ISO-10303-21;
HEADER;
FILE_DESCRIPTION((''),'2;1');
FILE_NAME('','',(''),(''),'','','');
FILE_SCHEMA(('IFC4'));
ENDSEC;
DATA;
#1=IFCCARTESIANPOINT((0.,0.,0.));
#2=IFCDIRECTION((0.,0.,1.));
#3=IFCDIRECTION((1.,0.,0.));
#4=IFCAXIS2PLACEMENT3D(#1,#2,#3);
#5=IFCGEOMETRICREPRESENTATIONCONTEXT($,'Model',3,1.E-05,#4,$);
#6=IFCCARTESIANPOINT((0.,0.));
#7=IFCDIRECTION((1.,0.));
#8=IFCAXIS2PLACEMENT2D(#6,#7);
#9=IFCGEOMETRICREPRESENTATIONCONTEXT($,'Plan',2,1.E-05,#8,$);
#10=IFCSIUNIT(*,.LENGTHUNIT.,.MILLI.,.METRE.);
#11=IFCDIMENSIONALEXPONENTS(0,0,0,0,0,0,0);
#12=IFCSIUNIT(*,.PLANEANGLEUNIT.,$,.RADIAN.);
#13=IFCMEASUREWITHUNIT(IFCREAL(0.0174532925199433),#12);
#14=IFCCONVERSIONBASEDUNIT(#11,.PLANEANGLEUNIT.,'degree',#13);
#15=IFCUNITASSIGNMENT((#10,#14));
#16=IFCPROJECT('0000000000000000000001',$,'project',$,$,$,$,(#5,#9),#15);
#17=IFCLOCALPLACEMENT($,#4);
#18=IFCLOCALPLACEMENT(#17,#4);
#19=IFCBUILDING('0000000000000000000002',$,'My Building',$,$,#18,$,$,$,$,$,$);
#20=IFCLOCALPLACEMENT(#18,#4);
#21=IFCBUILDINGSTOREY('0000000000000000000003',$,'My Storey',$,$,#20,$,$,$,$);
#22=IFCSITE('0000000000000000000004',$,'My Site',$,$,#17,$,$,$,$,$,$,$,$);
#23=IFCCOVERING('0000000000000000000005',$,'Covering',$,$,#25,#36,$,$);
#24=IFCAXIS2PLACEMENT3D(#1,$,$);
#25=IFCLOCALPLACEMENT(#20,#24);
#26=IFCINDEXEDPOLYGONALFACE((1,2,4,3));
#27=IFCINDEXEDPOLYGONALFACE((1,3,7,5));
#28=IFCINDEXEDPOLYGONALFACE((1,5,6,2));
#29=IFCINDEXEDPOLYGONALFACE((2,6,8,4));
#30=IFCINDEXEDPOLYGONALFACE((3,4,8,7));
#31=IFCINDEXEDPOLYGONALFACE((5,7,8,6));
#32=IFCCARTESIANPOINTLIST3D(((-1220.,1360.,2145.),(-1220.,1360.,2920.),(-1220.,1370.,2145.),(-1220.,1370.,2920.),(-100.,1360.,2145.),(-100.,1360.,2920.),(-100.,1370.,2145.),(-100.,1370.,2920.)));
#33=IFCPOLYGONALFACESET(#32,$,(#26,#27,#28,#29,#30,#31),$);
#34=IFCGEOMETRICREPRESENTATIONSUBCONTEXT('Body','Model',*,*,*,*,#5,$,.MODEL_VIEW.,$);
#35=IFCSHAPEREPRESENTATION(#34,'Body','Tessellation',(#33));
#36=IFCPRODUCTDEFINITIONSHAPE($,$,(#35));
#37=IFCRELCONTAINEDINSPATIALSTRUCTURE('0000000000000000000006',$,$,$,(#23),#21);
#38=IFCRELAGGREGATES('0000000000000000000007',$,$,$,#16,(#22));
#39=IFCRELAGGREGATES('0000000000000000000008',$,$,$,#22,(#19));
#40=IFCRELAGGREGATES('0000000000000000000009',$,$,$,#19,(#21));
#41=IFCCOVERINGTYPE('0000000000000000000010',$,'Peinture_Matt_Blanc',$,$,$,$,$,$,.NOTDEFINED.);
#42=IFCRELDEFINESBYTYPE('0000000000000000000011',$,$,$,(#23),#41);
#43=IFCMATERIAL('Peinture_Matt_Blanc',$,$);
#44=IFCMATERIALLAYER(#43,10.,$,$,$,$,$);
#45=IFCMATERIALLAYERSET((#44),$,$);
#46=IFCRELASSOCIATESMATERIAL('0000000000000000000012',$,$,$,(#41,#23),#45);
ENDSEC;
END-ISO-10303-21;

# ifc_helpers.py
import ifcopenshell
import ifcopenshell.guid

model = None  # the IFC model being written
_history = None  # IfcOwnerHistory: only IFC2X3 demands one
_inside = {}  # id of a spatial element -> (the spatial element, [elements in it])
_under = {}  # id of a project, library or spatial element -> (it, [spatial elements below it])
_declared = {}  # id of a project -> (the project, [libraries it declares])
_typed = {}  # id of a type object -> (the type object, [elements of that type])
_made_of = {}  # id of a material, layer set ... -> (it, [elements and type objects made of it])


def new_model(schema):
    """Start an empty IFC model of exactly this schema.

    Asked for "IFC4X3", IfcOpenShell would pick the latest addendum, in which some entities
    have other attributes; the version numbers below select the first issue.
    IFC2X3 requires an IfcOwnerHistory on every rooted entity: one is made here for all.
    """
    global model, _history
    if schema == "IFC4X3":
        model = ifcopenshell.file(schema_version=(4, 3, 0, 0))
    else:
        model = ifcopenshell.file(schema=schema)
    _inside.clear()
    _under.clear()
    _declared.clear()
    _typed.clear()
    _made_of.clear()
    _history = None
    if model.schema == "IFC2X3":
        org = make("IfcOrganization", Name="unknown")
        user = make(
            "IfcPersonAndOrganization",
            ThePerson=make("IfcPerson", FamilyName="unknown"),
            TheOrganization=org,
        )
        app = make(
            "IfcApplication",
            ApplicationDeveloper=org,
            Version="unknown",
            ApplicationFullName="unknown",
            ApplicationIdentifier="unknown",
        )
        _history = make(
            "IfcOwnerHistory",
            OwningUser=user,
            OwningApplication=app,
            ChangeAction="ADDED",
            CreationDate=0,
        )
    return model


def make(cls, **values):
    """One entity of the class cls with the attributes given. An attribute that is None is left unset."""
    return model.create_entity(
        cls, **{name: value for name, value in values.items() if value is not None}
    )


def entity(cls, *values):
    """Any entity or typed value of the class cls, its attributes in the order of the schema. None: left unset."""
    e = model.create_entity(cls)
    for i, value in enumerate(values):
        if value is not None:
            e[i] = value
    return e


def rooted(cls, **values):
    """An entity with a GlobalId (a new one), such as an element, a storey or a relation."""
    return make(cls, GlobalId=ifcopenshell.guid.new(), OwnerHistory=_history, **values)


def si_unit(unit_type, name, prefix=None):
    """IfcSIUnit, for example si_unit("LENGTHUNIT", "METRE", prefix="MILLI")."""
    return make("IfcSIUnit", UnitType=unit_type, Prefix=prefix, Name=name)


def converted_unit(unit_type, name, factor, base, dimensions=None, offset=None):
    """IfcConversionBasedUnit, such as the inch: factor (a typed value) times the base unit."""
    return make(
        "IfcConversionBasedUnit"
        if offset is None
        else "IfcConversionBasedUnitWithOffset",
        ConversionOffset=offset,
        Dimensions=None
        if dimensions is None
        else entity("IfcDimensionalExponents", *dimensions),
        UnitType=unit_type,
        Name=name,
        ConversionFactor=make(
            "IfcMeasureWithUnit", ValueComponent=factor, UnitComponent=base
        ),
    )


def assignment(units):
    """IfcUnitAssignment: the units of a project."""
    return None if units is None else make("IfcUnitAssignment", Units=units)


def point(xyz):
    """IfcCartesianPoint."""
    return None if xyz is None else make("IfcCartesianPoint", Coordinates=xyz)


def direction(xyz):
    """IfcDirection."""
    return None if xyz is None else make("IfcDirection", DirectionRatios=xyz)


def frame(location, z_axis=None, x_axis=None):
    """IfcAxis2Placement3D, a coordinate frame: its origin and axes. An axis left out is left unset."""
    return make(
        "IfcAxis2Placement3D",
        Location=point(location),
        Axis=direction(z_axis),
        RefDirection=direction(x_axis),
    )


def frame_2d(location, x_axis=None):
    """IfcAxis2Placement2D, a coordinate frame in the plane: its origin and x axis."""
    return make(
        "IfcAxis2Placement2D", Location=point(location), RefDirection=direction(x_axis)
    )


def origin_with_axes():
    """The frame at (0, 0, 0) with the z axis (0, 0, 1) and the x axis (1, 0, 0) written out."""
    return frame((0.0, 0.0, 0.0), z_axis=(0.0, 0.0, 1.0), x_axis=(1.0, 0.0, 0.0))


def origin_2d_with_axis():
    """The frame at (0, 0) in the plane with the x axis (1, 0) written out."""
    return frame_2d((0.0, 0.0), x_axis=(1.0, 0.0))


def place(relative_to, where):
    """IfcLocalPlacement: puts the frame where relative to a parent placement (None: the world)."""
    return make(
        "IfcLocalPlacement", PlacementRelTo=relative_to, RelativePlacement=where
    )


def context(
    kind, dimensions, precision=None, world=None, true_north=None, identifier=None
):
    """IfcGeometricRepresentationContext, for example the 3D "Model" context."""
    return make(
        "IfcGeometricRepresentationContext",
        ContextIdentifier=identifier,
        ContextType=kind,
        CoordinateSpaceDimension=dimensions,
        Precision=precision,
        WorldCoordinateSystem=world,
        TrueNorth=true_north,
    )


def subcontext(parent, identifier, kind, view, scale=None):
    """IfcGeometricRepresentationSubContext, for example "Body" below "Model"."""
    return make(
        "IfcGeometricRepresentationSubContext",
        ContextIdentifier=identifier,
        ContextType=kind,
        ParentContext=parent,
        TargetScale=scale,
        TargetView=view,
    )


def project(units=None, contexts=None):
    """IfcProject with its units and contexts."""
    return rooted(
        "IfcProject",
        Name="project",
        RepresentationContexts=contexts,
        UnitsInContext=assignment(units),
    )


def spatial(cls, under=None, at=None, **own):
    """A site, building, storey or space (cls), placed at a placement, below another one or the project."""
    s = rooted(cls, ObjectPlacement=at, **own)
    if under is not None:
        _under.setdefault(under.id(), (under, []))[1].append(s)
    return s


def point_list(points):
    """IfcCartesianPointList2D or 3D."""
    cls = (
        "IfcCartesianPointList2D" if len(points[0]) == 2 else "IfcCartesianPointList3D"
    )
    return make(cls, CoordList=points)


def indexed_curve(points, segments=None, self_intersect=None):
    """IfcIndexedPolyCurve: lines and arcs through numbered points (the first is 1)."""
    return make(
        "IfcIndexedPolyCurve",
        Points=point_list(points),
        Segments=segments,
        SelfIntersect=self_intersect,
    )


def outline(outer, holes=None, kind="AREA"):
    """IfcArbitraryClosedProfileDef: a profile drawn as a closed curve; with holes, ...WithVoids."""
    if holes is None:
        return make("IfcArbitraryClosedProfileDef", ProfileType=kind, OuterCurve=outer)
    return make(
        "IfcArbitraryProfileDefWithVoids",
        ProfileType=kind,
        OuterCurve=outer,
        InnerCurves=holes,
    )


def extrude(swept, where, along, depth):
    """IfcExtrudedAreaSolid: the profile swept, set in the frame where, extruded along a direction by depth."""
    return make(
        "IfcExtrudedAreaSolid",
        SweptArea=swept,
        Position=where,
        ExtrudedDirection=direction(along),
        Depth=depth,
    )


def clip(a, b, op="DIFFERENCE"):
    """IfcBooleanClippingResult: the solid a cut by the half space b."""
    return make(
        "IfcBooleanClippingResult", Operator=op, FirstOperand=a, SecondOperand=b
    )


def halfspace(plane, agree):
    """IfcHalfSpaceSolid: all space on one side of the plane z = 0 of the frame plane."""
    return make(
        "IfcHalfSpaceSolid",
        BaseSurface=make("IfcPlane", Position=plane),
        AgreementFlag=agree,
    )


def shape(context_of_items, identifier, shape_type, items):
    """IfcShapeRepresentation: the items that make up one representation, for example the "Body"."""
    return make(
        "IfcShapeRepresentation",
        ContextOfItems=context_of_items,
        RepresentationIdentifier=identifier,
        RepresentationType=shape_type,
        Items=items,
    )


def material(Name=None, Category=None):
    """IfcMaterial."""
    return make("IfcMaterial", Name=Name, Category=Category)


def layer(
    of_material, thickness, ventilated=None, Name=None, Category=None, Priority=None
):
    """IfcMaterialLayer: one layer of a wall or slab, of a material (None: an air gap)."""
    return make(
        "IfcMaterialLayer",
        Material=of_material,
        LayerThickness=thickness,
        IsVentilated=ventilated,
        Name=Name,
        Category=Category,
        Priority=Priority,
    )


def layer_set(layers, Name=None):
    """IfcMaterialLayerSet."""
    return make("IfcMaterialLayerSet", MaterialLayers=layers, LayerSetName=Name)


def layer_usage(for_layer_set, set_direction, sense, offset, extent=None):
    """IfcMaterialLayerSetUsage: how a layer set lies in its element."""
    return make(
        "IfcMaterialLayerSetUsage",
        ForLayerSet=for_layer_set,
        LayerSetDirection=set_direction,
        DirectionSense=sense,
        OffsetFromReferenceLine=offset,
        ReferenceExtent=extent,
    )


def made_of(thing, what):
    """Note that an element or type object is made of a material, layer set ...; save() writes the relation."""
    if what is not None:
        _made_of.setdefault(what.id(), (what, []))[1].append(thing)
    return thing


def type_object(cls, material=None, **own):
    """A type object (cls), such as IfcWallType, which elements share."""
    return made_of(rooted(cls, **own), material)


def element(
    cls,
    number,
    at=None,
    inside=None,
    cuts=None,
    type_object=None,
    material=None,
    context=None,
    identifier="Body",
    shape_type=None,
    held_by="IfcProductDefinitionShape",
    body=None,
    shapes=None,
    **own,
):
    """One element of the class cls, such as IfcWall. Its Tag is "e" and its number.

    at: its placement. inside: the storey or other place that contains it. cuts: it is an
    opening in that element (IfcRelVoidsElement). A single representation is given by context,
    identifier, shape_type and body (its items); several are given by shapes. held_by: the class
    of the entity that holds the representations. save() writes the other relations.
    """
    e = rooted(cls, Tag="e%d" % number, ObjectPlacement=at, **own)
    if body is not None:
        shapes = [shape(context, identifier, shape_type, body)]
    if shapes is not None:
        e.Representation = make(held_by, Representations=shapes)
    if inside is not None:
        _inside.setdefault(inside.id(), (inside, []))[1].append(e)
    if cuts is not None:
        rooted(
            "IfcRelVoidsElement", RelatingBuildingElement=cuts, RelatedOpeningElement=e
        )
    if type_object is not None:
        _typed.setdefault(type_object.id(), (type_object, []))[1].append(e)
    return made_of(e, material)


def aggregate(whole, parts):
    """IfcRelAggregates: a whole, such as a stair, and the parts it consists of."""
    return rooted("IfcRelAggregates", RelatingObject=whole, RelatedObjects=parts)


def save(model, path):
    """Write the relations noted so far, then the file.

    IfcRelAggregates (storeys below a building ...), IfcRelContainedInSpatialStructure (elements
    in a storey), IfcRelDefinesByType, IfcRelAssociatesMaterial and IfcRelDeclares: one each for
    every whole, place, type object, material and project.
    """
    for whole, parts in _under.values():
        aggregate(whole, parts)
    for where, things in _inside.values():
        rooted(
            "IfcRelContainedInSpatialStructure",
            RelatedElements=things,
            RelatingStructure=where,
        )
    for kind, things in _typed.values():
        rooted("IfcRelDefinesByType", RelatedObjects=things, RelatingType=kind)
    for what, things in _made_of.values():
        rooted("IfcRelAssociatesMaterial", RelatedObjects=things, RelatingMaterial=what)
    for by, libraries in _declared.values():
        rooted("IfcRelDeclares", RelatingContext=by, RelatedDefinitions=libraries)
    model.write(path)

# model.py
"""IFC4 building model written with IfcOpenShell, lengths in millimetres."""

from ifc_helpers import new_model, entity, si_unit, converted_unit, frame, origin_with_axes, origin_2d_with_axis, place, context, subcontext, project, spatial, indexed_curve, outline, extrude, clip, halfspace, material, layer, layer_set, layer_usage, type_object, element, save


model = new_model("IFC4")

# Units and contexts
model_context = context("Model", 3, precision=1e-05, world=origin_with_axes())
plan_context = context("Plan", 2, precision=1e-05, world=origin_2d_with_axis())
body_context_1 = subcontext(model_context, "Body", "Model", "MODEL_VIEW")
ifc_project = project(units=[si_unit("LENGTHUNIT", "METRE", prefix="MILLI"), converted_unit("PLANEANGLEUNIT", "degree", entity("IfcReal", 0.0174532925199433), si_unit("PLANEANGLEUNIT", "RADIAN"), dimensions=[0, 0, 0, 0, 0, 0, 0])], contexts=[model_context, plan_context])

# Site, building, storey
site_placement = place(None, origin_with_axes())
site = spatial("IfcSite", under=ifc_project, at=site_placement, Name="My Site")
building_placement = place(site_placement, origin_with_axes())
building = spatial("IfcBuilding", under=site, at=building_placement, Name="My Building")
storey_placement = place(building_placement, origin_with_axes())
storey = spatial("IfcBuildingStorey", under=building, at=storey_placement, Name="My Storey")

# Shared definitions
ifc_material_1 = material(Name="Peinture_Matt_Blanc")
ifc_layer_1 = layer(ifc_material_1, 10.0)
ifc_layer_set_1 = layer_set([ifc_layer_1])
covering_type_1 = type_object("IfcCoveringType", Name="Peinture_Matt_Blanc", PredefinedType="NOTDEFINED", material=ifc_layer_set_1)

# Covering
ifc_layer_usage_1 = layer_usage(ifc_layer_set_1, "AXIS2", "POSITIVE", 0.0)
covering_1_placement = place(storey_placement, frame((-100.0, 1370.0, 2145.0), z_axis=(0.0, 0.0, 1.0), x_axis=(-1.0, 0.000001, 0.0)))
element("IfcCovering", 1, at=covering_1_placement, inside=storey, type_object=covering_type_1, material=ifc_layer_usage_1, Name="Covering", context=body_context_1, shape_type="Clipping", body=[
    clip(extrude(outline(indexed_curve([(0.0, 0.0), (0.0, 10.0), (1120.0, 10.0), (1120.0, 0.0), (0.0, 0.0)], self_intersect=False)), origin_with_axes(), (0.0, 0.0, 1.0), 2920.0), halfspace(frame((0.0, 0.0, 775.0), z_axis=(0.0, 0.0, 1.0), x_axis=(-1.0, 0.0, 0.0)), False)),
])

save(model, "model.ifc")
